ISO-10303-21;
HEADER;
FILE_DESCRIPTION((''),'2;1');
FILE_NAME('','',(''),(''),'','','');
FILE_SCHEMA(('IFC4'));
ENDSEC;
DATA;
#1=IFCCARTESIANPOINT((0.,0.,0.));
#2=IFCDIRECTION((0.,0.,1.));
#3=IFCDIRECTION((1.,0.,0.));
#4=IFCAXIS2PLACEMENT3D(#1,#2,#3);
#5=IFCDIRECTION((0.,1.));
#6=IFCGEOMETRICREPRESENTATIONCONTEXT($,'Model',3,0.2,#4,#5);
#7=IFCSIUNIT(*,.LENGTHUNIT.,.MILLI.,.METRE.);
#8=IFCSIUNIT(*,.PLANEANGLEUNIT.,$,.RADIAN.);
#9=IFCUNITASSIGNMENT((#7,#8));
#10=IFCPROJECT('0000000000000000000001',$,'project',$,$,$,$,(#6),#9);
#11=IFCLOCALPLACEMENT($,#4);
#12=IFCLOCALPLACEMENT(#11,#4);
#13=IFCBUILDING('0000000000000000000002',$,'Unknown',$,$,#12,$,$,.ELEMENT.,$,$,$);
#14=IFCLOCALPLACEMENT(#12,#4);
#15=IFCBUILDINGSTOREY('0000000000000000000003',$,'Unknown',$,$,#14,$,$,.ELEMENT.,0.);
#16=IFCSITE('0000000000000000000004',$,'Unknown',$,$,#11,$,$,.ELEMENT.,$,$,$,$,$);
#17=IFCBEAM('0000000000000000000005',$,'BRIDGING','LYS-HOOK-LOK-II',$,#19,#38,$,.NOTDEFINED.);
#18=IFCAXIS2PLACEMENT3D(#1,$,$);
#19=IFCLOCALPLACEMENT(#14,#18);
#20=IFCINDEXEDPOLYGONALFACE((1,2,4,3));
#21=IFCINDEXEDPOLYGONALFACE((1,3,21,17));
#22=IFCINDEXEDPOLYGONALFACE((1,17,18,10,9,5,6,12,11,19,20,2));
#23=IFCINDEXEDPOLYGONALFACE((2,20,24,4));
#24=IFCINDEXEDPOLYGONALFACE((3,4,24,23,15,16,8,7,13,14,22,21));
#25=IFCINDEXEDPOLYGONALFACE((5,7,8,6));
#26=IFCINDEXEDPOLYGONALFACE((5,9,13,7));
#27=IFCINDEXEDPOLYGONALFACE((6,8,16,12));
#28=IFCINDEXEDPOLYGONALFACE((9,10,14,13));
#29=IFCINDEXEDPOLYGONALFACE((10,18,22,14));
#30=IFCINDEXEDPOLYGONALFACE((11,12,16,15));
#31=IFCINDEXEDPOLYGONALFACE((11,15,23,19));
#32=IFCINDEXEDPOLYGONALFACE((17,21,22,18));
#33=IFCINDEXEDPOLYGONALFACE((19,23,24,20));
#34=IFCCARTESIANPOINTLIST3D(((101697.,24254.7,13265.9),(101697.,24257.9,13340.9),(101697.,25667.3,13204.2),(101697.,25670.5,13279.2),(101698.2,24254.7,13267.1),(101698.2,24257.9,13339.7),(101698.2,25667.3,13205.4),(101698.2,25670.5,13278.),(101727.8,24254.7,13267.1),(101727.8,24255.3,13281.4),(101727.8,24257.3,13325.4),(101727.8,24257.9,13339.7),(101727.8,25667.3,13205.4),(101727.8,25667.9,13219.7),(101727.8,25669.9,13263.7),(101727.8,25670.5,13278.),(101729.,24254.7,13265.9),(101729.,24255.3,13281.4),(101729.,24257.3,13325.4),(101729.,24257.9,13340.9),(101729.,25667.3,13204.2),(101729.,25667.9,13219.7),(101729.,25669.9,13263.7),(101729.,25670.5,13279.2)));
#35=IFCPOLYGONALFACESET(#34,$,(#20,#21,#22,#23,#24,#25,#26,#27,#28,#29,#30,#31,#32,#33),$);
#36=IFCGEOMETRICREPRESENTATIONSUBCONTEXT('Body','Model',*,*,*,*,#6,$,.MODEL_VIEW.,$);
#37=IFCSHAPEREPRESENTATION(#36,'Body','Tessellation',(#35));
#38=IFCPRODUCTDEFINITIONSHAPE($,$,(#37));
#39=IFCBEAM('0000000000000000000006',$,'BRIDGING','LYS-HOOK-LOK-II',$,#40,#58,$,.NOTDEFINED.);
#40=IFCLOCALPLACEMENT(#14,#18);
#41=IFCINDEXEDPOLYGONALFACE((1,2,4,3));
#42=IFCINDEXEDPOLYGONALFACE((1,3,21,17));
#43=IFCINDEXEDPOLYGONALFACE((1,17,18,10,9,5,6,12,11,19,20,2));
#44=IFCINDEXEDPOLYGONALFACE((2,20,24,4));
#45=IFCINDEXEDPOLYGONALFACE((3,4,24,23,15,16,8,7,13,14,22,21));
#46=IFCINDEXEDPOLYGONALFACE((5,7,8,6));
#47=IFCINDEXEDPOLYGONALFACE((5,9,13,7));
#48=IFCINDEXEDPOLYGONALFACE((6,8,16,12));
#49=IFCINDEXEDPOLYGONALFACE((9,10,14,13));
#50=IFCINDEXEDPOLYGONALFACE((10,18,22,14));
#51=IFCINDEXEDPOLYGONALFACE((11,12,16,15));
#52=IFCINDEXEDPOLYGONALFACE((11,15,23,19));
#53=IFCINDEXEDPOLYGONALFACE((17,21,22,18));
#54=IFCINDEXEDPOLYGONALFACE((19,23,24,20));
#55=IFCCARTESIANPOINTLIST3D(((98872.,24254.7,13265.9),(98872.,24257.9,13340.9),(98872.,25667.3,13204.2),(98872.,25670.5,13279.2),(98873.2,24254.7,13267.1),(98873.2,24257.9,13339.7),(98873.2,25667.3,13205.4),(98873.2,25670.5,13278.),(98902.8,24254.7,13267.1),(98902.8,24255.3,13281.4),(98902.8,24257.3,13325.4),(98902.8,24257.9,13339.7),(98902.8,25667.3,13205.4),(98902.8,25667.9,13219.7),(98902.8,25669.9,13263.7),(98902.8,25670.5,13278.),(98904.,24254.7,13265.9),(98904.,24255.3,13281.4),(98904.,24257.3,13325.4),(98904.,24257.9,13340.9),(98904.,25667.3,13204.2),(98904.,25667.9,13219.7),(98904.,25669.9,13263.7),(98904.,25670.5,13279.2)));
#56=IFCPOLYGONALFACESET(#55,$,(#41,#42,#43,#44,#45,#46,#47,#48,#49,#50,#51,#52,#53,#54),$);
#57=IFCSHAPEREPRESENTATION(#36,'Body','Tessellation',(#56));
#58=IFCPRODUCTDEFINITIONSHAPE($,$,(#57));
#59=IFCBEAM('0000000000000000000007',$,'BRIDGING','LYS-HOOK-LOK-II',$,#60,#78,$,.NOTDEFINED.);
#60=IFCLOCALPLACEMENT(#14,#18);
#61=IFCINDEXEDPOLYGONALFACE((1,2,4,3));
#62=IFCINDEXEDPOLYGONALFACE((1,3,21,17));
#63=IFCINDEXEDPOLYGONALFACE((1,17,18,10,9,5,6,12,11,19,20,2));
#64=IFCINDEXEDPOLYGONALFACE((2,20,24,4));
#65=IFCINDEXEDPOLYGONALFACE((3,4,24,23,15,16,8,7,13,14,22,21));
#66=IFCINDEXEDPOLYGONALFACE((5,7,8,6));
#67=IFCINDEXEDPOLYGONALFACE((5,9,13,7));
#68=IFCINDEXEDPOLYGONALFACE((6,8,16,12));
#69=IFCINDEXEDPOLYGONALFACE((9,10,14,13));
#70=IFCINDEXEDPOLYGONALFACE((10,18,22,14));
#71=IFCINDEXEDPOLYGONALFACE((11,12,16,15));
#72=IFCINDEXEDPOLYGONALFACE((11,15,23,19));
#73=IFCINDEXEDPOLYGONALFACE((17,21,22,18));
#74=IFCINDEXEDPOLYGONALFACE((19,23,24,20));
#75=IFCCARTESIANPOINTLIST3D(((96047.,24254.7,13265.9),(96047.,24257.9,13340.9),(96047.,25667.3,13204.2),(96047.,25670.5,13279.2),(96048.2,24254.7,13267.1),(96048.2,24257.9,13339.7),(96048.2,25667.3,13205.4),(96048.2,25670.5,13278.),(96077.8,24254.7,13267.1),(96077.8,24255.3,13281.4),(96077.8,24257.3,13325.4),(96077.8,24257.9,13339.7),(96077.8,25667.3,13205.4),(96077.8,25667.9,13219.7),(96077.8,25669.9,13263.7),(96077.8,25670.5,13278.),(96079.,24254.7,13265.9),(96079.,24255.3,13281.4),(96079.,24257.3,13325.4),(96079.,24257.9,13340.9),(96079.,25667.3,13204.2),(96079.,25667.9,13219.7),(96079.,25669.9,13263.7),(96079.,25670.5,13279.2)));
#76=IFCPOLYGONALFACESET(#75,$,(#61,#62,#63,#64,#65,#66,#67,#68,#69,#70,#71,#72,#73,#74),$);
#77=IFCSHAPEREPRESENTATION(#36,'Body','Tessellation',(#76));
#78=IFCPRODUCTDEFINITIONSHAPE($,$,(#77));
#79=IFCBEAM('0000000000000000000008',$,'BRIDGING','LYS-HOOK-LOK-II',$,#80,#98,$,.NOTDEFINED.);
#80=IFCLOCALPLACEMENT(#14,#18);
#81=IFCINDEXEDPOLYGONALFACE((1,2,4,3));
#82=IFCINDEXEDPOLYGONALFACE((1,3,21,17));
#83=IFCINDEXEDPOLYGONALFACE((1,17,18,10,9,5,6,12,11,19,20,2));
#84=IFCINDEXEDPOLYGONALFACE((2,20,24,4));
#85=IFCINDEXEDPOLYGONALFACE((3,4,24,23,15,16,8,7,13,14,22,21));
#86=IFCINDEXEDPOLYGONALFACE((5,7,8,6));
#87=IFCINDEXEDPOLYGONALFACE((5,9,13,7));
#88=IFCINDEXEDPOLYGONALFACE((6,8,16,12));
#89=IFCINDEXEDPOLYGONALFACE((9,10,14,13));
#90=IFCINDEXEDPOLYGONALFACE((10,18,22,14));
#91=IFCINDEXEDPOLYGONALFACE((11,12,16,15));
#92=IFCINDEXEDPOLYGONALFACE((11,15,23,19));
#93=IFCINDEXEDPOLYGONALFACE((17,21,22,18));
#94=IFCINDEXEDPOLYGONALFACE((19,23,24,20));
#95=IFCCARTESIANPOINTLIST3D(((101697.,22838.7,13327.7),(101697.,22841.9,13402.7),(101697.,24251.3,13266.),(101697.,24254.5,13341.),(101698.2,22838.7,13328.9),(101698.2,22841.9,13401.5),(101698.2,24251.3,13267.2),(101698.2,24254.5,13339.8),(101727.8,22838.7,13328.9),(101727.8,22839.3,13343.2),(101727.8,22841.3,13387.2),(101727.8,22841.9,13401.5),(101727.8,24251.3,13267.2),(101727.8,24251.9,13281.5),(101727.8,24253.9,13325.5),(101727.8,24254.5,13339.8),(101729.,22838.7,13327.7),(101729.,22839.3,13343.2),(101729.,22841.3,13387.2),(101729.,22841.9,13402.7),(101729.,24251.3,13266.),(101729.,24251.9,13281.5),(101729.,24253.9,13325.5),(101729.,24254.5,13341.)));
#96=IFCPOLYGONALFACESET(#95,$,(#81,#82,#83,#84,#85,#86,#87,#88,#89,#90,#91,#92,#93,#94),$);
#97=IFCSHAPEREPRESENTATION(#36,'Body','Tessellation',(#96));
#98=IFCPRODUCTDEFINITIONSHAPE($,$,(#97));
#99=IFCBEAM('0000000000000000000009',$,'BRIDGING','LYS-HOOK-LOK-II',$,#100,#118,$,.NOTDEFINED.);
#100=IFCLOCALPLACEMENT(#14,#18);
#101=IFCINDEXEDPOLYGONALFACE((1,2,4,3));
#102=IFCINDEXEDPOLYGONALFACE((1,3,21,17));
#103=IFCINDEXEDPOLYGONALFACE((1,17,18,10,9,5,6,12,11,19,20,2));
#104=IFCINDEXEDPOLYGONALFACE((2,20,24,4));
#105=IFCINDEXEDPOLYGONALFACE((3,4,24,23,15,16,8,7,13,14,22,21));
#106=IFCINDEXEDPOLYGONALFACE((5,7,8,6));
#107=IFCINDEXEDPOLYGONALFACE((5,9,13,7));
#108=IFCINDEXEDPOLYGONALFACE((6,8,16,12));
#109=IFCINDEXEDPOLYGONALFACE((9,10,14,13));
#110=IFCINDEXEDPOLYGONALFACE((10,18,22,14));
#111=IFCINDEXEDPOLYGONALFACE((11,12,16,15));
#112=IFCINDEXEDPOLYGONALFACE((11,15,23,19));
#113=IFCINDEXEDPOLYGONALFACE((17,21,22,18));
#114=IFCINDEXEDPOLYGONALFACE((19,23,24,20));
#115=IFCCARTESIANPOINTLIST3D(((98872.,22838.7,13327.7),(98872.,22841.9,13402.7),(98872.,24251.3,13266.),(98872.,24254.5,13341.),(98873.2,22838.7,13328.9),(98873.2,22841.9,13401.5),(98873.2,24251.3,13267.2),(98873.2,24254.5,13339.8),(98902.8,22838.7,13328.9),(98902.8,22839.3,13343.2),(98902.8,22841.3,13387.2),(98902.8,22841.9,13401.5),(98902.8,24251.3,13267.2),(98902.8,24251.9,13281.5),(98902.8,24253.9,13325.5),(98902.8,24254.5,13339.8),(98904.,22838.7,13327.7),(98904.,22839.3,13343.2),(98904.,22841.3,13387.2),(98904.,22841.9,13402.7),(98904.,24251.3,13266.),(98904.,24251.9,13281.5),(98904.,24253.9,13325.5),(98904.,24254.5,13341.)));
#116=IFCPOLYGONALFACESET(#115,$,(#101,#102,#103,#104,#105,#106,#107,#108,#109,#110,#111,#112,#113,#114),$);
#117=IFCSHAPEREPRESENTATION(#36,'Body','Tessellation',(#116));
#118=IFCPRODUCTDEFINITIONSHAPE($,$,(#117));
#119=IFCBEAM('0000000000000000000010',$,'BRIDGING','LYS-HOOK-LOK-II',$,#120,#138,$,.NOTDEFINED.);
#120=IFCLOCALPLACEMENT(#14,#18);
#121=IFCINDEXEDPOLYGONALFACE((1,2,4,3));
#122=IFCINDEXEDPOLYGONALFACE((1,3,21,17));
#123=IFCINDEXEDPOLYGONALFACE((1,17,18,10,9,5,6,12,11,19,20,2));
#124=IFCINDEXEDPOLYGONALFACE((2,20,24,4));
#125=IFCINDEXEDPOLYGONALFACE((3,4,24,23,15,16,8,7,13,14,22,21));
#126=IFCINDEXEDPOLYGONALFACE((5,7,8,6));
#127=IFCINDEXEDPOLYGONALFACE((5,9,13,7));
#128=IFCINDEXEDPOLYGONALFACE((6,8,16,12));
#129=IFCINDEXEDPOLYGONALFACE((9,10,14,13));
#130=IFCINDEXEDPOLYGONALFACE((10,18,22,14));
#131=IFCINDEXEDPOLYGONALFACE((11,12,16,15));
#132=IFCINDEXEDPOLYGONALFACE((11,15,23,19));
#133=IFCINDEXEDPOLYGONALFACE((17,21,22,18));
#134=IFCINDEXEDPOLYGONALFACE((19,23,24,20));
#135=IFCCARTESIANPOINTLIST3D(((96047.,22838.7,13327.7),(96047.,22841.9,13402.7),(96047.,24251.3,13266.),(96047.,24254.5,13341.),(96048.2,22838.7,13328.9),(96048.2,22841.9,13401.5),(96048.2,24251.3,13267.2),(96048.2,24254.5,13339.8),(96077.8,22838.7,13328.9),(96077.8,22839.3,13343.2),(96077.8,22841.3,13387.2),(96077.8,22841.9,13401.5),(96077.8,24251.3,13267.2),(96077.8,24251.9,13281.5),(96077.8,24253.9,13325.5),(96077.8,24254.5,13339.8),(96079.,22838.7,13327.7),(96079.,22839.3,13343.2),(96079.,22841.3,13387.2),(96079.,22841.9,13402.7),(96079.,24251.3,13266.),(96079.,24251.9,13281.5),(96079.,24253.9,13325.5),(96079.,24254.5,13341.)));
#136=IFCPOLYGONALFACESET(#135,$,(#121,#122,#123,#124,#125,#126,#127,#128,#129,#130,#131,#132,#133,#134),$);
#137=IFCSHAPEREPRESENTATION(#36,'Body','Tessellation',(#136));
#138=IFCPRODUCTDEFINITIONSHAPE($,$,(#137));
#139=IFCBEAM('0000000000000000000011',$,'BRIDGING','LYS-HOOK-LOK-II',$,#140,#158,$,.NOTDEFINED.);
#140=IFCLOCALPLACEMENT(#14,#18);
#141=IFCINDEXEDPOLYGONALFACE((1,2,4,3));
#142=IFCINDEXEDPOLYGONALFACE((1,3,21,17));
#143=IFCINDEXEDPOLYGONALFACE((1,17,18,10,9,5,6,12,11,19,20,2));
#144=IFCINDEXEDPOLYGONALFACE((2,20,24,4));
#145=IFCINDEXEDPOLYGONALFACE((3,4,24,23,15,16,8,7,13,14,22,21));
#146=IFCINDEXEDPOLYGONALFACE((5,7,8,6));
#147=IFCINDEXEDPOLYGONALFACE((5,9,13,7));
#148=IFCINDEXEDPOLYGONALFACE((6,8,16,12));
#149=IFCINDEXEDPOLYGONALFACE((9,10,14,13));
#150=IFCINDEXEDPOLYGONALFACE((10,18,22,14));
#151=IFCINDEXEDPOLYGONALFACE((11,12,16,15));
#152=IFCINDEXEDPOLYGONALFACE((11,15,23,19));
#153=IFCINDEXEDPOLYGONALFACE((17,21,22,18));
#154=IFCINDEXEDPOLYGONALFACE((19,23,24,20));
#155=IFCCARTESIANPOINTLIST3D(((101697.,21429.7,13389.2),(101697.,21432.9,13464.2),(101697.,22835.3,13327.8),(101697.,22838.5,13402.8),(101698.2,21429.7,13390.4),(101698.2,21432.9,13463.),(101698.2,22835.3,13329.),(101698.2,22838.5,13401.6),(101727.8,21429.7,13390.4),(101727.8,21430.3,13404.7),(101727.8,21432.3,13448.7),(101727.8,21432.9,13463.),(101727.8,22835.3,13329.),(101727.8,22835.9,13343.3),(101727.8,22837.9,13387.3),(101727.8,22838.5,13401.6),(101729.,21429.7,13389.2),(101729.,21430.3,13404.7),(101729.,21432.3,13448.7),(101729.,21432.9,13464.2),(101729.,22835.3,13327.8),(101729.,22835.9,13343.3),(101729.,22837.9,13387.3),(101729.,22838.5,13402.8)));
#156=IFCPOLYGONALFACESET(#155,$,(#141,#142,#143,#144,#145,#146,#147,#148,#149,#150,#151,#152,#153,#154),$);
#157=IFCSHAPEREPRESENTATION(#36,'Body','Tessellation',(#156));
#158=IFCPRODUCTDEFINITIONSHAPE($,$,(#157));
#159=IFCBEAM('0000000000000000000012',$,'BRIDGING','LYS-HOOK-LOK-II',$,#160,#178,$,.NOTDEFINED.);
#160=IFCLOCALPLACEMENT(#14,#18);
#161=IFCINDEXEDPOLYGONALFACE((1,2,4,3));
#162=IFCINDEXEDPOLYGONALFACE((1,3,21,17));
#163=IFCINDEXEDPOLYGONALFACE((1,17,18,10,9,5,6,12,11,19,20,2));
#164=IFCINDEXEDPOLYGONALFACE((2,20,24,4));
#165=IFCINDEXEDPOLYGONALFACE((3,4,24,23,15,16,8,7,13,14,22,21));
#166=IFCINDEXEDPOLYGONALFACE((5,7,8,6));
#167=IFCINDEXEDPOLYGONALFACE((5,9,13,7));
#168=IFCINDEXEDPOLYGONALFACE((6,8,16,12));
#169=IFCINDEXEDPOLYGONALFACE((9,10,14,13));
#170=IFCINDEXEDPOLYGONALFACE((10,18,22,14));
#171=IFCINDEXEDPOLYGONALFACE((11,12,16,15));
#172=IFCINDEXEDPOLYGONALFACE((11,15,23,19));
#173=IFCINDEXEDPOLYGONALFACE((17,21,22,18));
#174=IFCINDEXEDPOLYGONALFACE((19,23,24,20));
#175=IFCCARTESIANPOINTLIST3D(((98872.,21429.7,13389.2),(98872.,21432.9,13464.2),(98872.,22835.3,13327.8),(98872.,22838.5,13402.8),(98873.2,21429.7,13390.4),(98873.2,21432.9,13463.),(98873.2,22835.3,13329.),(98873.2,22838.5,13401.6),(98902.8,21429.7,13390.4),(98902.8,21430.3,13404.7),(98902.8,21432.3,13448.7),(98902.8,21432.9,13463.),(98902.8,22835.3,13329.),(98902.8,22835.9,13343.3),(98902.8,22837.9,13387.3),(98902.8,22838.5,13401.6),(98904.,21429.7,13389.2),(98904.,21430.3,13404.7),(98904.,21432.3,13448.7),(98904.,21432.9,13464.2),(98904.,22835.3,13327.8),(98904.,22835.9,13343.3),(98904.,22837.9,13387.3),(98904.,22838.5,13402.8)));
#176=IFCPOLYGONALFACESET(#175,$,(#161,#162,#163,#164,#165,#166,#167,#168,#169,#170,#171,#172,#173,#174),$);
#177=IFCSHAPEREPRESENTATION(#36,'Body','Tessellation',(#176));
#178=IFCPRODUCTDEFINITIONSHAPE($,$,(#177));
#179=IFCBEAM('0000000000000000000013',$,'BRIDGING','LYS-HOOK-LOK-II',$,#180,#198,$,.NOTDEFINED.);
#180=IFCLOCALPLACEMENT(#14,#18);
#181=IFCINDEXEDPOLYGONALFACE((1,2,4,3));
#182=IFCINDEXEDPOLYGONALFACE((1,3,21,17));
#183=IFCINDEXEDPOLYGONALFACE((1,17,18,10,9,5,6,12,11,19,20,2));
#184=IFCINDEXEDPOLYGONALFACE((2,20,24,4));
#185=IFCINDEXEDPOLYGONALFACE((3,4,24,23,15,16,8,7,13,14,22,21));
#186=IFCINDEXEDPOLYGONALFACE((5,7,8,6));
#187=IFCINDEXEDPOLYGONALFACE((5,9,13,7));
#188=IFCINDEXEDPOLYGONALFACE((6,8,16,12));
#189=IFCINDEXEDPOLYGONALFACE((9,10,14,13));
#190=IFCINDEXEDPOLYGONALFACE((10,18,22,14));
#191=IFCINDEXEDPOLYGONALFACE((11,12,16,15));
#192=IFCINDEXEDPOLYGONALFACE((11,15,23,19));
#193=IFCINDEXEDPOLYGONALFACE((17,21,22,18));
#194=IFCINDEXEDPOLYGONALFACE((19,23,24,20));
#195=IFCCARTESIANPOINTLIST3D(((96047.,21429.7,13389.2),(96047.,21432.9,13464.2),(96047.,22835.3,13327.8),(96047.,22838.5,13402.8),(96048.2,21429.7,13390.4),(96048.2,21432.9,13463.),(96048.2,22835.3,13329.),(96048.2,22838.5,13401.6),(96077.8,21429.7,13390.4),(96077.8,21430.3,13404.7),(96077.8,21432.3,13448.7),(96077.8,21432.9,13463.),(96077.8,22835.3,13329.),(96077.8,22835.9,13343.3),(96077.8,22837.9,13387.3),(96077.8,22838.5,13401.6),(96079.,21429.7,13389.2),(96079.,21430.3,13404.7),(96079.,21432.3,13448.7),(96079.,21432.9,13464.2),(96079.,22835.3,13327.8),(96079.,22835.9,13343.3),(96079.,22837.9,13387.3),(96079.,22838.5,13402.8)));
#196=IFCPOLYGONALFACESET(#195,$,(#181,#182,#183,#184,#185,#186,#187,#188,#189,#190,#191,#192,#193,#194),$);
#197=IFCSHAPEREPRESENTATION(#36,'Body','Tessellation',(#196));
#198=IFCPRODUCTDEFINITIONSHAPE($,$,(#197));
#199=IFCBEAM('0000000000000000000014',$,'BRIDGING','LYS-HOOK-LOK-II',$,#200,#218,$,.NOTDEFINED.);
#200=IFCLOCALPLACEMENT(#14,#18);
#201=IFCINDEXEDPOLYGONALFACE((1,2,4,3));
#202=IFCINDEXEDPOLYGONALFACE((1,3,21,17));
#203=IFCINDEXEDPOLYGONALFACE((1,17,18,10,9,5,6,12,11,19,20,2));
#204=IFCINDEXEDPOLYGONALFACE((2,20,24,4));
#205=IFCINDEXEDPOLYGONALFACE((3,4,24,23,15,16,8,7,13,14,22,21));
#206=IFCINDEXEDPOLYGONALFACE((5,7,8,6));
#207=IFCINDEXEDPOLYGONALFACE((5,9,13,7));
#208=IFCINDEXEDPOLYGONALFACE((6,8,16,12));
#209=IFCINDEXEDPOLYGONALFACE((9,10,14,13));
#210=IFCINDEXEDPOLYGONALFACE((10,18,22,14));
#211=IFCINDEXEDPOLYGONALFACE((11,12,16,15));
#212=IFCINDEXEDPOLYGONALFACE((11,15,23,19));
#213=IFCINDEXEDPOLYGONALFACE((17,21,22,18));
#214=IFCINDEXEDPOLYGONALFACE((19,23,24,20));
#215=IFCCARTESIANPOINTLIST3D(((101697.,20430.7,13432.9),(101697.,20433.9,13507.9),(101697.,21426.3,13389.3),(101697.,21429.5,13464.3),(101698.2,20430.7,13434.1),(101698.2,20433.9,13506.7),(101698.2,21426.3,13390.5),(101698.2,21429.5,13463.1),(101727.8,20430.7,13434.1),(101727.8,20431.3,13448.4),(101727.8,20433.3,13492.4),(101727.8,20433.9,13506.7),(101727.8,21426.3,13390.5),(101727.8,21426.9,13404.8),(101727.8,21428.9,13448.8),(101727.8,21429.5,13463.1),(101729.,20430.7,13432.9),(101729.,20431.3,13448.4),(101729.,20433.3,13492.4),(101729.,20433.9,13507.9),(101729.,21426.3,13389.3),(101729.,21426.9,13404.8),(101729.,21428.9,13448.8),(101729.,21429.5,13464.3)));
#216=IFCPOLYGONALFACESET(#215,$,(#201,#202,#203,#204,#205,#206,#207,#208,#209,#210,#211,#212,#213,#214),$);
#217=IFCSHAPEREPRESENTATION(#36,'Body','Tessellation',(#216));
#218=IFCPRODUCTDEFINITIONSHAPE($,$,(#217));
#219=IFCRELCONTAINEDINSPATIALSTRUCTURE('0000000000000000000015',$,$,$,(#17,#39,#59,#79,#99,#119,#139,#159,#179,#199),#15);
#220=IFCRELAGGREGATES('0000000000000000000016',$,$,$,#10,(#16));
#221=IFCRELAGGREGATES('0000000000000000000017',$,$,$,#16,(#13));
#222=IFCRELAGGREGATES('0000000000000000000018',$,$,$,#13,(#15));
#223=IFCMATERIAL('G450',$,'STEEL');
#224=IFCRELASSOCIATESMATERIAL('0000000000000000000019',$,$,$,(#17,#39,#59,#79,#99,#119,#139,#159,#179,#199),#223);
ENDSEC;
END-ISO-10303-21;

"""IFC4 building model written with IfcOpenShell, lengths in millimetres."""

from ifc_helpers import new_model, si_unit, direction, frame, origin_with_axes, place, context, subcontext, project, spatial, line, indexed_curve, outline, extrude, material, element, save


model = new_model("IFC4")

# Units and contexts
model_context = context("Model", 3, precision=0.2, world=origin_with_axes(), true_north=direction((0.0, 1.0)))
body_context = subcontext(model_context, "Body", "Model", "MODEL_VIEW")
ifc_project = project(units=[si_unit("LENGTHUNIT", "METRE", prefix="MILLI"), si_unit("PLANEANGLEUNIT", "RADIAN")], contexts=[model_context])

# Site, building, storey
site_placement = place(None, origin_with_axes())
site = spatial("IfcSite", under=ifc_project, at=site_placement, Name="Unknown", CompositionType="ELEMENT")
building_placement = place(site_placement, origin_with_axes())
building = spatial("IfcBuilding", under=site, at=building_placement, Name="Unknown", CompositionType="ELEMENT")
storey_placement = place(building_placement, origin_with_axes())
storey = spatial("IfcBuildingStorey", under=building, at=storey_placement, Name="Unknown", CompositionType="ELEMENT", Elevation=0.0)

# Beams
ifc_material_1 = material(Name="G450", Category="STEEL")
for number, where, z_axis, x_axis, name in (
    (1, (101713.0, 24256.3, 13303.4), (1.0, 0.0, 0.0), (0.0, 0.999047, -0.043637), "BRIDGING"),
    (2, (98888.0, 24256.3, 13303.4), (1.0, 0.0, 0.0), (0.0, 0.999047, -0.043637), "BRIDGING"),
    (3, (96063.0, 24256.3, 13303.4), (1.0, 0.0, 0.0), (0.0, 0.999047, -0.043637), "BRIDGING"),
    (4, (101713.0, 22840.3, 13365.2), (1.0, 0.0, 0.0), (0.0, 0.999047, -0.043637), "BRIDGING"),
    (5, (98888.0, 22840.3, 13365.2), (1.0, 0.0, 0.0), (0.0, 0.999047, -0.043637), "BRIDGING"),
    (6, (96063.0, 22840.3, 13365.2), (1.0, 0.0, 0.0), (0.0, 0.999047, -0.043637), "BRIDGING"),
):
    element("IfcBeam", number, at=place(storey_placement, frame(where, z_axis=z_axis, x_axis=x_axis)), inside=storey, material=ifc_material_1, Name=name, Description="LYS-HOOK-LOK-II", PredefinedType="NOTDEFINED", context=body_context, shape_type="SolidModel", body=[
        extrude(outline(indexed_curve([(16.0, -37.5), (16.0, -22.0), (14.8, -22.0), (14.8, -36.3), (-14.8, -36.3), (-14.8, 36.3), (14.8, 36.3), (14.8, 22.0), (16.0, 22.0), (16.0, 37.5), (-16.0, 37.5), (-16.0, -37.5)], segments=[line(1, 2, 3, 4, 5, 6, 7, 8, 9, 10, 11, 12, 1)])), frame((0.0, 0.0, 0.0), z_axis=(-1.0, 0.0, 0.0), x_axis=(0.0, 0.0, 1.0)), (0.0, 0.0, -1.0), 1413.9),
    ])
for number, where, z_axis, x_axis, name in (
    (7, (101713.0, 21431.3, 13426.7), (1.0, 0.0, 0.0), (0.0, 0.999047, -0.043641), "BRIDGING"),
    (8, (98888.0, 21431.3, 13426.7), (1.0, 0.0, 0.0), (0.0, 0.999047, -0.043641), "BRIDGING"),
    (9, (96063.0, 21431.3, 13426.7), (1.0, 0.0, 0.0), (0.0, 0.999047, -0.043641), "BRIDGING"),
):
    element("IfcBeam", number, at=place(storey_placement, frame(where, z_axis=z_axis, x_axis=x_axis)), inside=storey, material=ifc_material_1, Name=name, Description="LYS-HOOK-LOK-II", PredefinedType="NOTDEFINED", context=body_context, shape_type="SolidModel", body=[
        extrude(outline(indexed_curve([(16.0, -37.5), (16.0, -22.0), (14.8, -22.0), (14.8, -36.3), (-14.8, -36.3), (-14.8, 36.3), (14.8, 36.3), (14.8, 22.0), (16.0, 22.0), (16.0, 37.5), (-16.0, 37.5), (-16.0, -37.5)], segments=[line(1, 2, 3, 4, 5, 6, 7, 8, 9, 10, 11, 12, 1)])), frame((0.0, 0.0, 0.0), z_axis=(-1.0, 0.0, 0.0), x_axis=(0.0, 0.0, 1.0)), (0.0, 0.0, -1.0), 1406.9),
    ])
for number, where, z_axis, x_axis, name in (
    (10, (101713.0, 20432.3, 13470.4), (1.0, 0.0, 0.0), (0.0, 0.999042, -0.043751), "BRIDGING"),
):
    element("IfcBeam", number, at=place(storey_placement, frame(where, z_axis=z_axis, x_axis=x_axis)), inside=storey, material=ifc_material_1, Name=name, Description="LYS-HOOK-LOK-II", PredefinedType="NOTDEFINED", context=body_context, shape_type="SolidModel", body=[
        extrude(outline(indexed_curve([(16.0, -37.5), (16.0, -22.0), (14.8, -22.0), (14.8, -36.3), (-14.8, -36.3), (-14.8, 36.3), (14.8, 36.3), (14.8, 22.0), (16.0, 22.0), (16.0, 37.5), (-16.0, 37.5), (-16.0, -37.5)], segments=[line(1, 2, 3, 4, 5, 6, 7, 8, 9, 10, 11, 12, 1)])), frame((0.0, 0.0, 0.0), z_axis=(-1.0, 0.0, 0.0), x_axis=(0.0, 0.0, 1.0)), (0.0, 0.0, -1.0), 996.6),
    ])

save(model, "model.ifc")
